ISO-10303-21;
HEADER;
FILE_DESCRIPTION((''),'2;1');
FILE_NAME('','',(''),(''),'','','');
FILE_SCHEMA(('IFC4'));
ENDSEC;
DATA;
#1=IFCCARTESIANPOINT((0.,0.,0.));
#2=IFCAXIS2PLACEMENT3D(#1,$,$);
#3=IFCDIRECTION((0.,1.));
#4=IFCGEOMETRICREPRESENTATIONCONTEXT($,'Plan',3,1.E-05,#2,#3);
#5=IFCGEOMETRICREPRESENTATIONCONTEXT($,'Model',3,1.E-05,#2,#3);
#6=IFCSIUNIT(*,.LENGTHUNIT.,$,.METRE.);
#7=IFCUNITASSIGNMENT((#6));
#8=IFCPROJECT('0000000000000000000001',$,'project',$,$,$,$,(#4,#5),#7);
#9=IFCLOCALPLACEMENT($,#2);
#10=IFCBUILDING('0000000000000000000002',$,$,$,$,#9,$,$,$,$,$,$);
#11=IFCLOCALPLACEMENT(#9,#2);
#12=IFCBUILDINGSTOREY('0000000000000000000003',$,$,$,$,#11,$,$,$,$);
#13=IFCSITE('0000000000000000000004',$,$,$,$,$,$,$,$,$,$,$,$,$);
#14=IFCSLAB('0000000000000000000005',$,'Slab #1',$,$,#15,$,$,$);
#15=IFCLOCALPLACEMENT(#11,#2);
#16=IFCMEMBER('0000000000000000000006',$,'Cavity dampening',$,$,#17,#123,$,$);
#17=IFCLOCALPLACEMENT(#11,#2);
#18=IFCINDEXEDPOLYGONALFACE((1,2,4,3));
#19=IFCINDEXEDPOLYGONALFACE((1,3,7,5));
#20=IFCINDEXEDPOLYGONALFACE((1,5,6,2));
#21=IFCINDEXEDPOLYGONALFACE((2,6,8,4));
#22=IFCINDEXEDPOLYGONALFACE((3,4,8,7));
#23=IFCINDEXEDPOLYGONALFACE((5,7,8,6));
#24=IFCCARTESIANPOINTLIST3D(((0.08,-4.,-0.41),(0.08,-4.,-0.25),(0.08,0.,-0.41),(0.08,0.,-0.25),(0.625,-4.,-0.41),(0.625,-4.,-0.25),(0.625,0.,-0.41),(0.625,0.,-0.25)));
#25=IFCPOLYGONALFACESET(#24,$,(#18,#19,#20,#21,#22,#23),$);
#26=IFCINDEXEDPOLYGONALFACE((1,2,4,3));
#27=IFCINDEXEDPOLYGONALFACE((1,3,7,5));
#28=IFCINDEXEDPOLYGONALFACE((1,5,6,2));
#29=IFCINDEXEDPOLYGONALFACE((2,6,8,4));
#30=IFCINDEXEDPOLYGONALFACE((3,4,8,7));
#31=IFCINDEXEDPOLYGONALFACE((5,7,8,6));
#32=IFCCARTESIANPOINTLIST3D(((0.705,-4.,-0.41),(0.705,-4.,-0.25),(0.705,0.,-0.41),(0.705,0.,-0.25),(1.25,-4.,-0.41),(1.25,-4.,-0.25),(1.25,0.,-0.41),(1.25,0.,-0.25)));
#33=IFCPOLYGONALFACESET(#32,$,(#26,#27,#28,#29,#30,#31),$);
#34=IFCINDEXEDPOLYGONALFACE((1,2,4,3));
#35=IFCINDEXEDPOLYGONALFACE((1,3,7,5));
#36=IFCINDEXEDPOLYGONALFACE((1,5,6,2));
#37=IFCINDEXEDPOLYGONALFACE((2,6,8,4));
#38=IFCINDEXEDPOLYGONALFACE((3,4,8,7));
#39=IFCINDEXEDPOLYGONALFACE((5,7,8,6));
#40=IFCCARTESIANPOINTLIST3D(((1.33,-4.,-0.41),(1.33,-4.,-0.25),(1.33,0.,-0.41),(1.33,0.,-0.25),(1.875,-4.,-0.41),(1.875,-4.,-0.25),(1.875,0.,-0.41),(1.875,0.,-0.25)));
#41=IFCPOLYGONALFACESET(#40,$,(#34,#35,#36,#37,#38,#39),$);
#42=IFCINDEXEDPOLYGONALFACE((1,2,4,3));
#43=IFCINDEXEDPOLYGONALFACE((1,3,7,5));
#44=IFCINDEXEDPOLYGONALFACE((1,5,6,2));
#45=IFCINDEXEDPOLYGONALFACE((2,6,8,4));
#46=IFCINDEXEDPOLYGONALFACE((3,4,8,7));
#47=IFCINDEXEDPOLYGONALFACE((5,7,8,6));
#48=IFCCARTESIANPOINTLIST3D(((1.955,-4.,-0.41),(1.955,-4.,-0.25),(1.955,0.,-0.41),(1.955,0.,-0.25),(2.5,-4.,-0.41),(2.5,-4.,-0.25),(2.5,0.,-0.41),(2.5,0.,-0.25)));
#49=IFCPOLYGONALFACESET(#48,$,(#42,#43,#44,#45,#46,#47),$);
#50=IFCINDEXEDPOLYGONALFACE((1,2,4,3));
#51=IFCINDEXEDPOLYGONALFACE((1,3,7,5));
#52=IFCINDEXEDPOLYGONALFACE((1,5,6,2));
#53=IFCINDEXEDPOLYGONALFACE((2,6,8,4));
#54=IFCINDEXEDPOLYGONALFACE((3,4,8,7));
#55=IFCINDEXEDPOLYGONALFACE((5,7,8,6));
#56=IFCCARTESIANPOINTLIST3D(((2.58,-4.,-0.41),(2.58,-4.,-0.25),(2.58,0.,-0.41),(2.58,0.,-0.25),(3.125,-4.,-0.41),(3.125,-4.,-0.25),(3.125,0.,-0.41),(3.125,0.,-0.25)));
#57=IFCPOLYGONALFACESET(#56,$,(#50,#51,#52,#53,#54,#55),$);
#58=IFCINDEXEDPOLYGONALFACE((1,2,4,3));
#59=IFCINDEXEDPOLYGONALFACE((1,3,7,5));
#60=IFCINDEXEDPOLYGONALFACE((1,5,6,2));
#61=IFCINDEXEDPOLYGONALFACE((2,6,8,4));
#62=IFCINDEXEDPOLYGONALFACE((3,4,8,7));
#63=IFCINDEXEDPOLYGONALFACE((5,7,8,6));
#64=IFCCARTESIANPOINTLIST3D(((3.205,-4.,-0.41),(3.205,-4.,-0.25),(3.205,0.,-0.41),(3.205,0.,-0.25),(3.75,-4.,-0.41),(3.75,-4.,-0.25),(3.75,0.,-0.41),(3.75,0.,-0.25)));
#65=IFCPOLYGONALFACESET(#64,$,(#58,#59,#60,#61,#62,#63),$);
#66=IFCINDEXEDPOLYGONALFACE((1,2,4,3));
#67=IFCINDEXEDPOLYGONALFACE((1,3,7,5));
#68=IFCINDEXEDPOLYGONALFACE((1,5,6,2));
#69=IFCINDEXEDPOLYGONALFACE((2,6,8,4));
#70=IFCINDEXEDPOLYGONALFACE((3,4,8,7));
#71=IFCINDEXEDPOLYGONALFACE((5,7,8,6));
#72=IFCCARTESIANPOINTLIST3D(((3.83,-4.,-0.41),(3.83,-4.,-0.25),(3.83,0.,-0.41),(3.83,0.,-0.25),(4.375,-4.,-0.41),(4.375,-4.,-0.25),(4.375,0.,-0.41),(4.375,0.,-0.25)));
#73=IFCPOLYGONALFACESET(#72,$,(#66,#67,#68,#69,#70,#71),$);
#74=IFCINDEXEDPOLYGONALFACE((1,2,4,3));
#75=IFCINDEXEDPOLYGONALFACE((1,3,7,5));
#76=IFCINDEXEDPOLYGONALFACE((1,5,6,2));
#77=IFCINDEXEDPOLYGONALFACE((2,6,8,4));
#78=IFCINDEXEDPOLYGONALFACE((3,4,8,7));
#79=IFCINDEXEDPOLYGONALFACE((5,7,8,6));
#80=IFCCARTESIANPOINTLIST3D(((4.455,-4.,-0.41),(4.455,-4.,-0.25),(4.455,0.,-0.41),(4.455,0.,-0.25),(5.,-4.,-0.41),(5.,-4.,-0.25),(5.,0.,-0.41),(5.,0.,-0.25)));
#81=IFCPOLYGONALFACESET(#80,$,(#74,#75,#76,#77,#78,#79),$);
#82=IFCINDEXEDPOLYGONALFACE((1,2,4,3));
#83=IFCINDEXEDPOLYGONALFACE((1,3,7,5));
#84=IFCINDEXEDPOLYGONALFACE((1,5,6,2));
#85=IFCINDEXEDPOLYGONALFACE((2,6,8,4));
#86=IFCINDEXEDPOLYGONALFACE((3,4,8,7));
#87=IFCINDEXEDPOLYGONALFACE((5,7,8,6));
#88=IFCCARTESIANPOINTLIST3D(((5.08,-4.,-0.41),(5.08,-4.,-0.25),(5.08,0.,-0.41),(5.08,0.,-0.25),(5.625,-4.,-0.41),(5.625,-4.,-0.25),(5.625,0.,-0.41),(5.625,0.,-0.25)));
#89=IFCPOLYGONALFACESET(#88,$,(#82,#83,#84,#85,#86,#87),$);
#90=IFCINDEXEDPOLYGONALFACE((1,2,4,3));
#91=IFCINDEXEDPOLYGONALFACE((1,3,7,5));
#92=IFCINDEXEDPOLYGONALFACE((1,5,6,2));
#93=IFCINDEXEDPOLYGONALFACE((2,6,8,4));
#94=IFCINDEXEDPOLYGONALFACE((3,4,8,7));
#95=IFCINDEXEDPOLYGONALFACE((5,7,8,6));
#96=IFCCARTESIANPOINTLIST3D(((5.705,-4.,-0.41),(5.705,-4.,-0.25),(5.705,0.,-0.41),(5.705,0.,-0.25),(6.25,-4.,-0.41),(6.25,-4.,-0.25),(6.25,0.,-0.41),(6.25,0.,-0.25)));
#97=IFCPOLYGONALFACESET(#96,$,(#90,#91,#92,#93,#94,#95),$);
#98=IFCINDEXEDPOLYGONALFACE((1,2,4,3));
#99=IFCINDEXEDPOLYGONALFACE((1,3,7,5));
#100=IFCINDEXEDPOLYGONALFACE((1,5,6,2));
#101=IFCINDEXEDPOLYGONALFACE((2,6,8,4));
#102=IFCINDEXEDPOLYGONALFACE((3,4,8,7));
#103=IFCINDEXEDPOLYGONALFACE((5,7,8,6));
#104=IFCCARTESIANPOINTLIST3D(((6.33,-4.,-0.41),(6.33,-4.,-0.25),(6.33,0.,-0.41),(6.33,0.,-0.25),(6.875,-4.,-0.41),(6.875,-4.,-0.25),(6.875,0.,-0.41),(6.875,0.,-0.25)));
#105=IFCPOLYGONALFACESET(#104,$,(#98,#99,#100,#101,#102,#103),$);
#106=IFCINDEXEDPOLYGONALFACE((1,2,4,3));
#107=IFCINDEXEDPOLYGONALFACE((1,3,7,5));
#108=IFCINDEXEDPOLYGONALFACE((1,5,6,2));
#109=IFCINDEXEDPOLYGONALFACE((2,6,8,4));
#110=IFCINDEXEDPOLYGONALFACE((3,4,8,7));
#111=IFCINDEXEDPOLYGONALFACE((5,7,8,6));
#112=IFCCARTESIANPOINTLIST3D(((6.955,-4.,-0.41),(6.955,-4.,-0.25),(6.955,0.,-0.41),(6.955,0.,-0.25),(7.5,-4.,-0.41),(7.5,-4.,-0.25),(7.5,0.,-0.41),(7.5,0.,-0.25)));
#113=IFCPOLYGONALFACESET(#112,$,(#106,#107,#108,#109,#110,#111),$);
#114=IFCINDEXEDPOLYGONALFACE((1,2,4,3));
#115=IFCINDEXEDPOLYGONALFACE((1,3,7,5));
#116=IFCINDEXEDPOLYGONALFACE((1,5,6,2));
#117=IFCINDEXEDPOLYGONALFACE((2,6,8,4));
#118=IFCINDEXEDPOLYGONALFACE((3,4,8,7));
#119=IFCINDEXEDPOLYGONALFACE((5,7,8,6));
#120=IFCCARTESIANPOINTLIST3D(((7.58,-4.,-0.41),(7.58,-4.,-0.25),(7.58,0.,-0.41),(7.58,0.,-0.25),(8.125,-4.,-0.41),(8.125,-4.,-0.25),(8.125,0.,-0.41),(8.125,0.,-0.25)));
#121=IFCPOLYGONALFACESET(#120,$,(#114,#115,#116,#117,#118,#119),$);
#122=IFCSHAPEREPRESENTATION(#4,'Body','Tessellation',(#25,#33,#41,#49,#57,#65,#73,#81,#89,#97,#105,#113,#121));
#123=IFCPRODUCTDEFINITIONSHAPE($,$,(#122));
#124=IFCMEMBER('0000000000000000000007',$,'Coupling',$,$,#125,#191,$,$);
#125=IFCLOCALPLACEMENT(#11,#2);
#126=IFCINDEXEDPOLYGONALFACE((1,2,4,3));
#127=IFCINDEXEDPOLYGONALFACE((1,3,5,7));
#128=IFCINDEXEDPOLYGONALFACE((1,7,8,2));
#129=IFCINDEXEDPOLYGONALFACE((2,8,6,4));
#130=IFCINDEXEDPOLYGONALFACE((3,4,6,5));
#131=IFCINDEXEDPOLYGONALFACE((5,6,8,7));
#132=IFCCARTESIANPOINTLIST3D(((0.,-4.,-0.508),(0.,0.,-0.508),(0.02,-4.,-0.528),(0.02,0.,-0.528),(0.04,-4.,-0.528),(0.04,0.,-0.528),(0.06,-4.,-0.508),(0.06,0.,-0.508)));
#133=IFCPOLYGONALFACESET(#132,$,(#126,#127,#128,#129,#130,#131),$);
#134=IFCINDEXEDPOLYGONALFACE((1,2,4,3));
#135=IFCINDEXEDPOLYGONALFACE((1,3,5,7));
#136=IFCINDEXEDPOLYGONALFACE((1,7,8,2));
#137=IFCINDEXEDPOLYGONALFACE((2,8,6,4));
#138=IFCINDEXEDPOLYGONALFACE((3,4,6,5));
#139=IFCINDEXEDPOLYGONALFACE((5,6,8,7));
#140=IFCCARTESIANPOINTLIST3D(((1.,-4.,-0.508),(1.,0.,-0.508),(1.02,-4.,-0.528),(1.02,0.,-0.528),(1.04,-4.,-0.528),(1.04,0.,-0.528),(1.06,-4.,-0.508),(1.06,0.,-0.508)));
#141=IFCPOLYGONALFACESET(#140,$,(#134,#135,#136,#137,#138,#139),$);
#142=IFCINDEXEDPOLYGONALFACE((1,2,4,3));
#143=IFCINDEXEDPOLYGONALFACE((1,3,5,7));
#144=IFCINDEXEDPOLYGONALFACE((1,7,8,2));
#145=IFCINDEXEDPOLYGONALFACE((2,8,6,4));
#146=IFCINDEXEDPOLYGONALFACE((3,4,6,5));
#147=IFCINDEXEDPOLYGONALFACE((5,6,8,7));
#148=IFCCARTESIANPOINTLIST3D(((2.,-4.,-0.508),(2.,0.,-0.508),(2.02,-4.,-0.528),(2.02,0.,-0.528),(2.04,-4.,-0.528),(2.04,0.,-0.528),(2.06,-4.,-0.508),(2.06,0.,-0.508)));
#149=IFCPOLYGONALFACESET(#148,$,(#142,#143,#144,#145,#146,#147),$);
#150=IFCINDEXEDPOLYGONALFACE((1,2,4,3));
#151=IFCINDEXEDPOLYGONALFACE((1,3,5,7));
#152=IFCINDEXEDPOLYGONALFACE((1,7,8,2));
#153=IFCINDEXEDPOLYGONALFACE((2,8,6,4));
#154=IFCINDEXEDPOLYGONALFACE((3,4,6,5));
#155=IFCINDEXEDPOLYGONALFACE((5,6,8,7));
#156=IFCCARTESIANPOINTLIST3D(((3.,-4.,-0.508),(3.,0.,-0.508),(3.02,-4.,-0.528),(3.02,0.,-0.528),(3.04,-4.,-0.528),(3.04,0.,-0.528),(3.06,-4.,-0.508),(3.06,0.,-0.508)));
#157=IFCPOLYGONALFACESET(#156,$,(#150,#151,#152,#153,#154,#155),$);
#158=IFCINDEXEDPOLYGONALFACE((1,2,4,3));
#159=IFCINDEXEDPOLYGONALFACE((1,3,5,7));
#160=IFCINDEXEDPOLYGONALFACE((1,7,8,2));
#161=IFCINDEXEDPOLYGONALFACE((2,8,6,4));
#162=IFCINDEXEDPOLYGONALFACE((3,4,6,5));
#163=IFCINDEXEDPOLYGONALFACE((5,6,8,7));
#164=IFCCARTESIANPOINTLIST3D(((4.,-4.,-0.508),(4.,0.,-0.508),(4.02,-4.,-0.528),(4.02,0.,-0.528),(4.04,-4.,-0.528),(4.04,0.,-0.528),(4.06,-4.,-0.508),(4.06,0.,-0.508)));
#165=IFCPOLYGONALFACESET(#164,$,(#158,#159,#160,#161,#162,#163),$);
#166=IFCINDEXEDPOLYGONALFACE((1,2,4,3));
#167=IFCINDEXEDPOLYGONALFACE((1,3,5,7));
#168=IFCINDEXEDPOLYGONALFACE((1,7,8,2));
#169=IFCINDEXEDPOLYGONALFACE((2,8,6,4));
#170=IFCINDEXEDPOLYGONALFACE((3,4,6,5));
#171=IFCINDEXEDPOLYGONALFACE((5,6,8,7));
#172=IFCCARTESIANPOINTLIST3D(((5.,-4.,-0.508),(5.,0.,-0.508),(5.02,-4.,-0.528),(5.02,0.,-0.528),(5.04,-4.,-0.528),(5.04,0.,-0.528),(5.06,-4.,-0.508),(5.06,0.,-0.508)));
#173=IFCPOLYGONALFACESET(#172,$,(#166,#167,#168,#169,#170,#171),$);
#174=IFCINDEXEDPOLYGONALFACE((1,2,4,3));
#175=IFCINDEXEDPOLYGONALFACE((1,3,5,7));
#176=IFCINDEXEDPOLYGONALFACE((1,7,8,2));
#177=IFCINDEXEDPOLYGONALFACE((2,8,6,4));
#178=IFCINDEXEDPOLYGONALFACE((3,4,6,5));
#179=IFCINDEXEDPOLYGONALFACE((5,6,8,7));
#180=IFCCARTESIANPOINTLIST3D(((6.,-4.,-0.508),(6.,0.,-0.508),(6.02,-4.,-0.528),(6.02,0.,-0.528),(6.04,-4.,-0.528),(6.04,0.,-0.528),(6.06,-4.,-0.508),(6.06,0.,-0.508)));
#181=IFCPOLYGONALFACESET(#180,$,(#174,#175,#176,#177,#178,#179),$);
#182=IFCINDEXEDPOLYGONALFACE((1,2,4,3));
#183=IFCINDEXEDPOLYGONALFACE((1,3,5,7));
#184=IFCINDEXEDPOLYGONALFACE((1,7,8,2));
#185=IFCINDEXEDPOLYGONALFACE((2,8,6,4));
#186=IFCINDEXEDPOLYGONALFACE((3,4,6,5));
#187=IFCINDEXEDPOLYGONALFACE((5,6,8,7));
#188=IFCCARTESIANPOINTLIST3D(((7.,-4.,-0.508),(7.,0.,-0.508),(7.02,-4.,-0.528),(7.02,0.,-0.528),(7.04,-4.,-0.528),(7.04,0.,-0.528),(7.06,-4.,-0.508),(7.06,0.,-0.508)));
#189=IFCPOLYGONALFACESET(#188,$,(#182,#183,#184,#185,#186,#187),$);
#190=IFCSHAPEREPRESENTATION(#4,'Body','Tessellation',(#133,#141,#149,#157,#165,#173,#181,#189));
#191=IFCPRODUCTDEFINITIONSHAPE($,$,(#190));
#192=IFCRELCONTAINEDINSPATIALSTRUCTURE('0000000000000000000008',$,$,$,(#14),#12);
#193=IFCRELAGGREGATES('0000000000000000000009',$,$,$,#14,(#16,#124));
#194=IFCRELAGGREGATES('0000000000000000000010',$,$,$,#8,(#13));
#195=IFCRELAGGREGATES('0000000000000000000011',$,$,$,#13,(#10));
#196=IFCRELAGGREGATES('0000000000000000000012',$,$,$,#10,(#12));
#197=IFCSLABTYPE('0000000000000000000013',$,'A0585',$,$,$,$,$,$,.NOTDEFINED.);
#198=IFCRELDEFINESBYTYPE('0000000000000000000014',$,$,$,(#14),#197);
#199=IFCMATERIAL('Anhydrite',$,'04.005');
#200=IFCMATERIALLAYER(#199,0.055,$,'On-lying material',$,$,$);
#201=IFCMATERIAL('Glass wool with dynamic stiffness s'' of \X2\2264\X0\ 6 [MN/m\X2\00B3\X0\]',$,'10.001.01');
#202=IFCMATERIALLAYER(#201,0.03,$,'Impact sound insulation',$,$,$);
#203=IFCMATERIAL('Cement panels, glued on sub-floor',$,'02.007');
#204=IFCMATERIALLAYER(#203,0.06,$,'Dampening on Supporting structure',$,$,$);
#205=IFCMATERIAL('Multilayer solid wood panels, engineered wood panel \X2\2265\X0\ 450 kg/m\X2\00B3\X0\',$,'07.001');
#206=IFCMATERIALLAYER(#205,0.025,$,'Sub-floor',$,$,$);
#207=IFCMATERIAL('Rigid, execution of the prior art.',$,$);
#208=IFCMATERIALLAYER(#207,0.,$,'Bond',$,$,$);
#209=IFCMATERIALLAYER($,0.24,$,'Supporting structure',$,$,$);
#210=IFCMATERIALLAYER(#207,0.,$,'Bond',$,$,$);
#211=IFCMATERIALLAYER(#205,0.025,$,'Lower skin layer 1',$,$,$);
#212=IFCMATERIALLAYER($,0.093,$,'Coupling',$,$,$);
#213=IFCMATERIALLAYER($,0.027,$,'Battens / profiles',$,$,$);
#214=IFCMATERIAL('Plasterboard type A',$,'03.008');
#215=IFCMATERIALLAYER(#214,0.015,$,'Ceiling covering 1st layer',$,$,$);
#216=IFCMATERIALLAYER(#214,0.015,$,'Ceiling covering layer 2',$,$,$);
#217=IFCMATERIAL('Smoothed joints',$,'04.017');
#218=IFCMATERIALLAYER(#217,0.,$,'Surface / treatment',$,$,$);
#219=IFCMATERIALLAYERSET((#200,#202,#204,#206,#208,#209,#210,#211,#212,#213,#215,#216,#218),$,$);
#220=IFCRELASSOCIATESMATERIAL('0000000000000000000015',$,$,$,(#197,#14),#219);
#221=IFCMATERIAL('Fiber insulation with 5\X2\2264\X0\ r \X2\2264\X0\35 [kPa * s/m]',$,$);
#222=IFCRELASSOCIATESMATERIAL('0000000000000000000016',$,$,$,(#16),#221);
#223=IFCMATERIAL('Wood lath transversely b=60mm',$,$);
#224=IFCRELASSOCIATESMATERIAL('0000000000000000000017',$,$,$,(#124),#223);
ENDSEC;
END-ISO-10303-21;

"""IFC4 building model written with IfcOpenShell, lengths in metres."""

from ifc_helpers import new_model, si_unit, direction, frame, frame_2d, origin, place, context, project, spatial, polyline, rectangle, outline, extrude, material, layer, layer_set, type_object, element, aggregate, save


model = new_model("IFC4")

# Units and contexts
plan_context = context("Plan", 3, precision=1e-05, world=origin(), true_north=direction((0.0, 1.0)))
model_context = context("Model", 3, precision=1e-05, world=origin(), true_north=direction((0.0, 1.0)))
ifc_project = project(units=[si_unit("LENGTHUNIT", "METRE")], contexts=[plan_context, model_context])

# Site, building, storey
site = spatial("IfcSite", under=ifc_project)
building_placement = place(None, origin())
building = spatial("IfcBuilding", under=site, at=building_placement)
storey_placement = place(building_placement, origin())
storey = spatial("IfcBuildingStorey", under=building, at=storey_placement)

# Slab, members
ifc_material_1 = material(Name="Anhydrite", Category="04.005")
ifc_layer_1 = layer(ifc_material_1, 0.055, Name="On-lying material")
ifc_material_2 = material(Name="Glass wool with dynamic stiffness s' of ≤ 6 [MN/m³]", Category="10.001.01")
ifc_layer_2 = layer(ifc_material_2, 0.03, Name="Impact sound insulation")
ifc_material_3 = material(Name="Cement panels, glued on sub-floor", Category="02.007")
ifc_layer_3 = layer(ifc_material_3, 0.06, Name="Dampening on Supporting structure")
ifc_material_4 = material(Name="Multilayer solid wood panels, engineered wood panel ≥ 450 kg/m³", Category="07.001")
ifc_layer_4 = layer(ifc_material_4, 0.025, Name="Sub-floor")
ifc_material_5 = material(Name="Rigid, execution of the prior art.")
ifc_layer_5 = layer(ifc_material_5, 0.0, Name="Bond")
ifc_layer_6 = layer(None, 0.24, Name="Supporting structure")
ifc_layer_7 = layer(ifc_material_5, 0.0, Name="Bond")
ifc_layer_8 = layer(ifc_material_4, 0.025, Name="Lower skin layer 1")
ifc_layer_9 = layer(None, 0.093, Name="Coupling")
ifc_layer_10 = layer(None, 0.027, Name="Battens / profiles")
ifc_material_6 = material(Name="Plasterboard type A", Category="03.008")
ifc_layer_11 = layer(ifc_material_6, 0.015, Name="Ceiling covering 1st layer")
ifc_layer_12 = layer(ifc_material_6, 0.015, Name="Ceiling covering layer 2")
ifc_material_7 = material(Name="Smoothed joints", Category="04.017")
ifc_layer_13 = layer(ifc_material_7, 0.0, Name="Surface / treatment")
ifc_layer_set = layer_set([ifc_layer_1, ifc_layer_2, ifc_layer_3, ifc_layer_4, ifc_layer_5, ifc_layer_6, ifc_layer_7, ifc_layer_8, ifc_layer_9, ifc_layer_10, ifc_layer_11, ifc_layer_12, ifc_layer_13])
slab_type = type_object("IfcSlabType", Name="A0585", PredefinedType="NOTDEFINED", material=ifc_layer_set)
slab_placement = place(None, frame((0.0, 0.0, 0.0), z_axis=(0.0, 0.0, -1.0), x_axis=(1.0, 0.0, 0.0)))
slab = element("IfcSlab", 1, at=slab_placement, inside=storey, type_object=slab_type, material=ifc_layer_set, Name="Slab #1")
ifc_material_8 = material(Name="Fiber insulation with 5≤ r ≤35 [kPa * s/m]")
member_1_placement = place(slab_placement, origin())
member_1 = element("IfcMember", 2, at=member_1_placement, material=ifc_material_8, Name="Cavity dampening", context=plan_context, shape_type="SweptSolid", body=[
    extrude(rectangle(XDim=0.545, YDim=0.16, at=frame_2d((0.2725, 0.08), x_axis=(1.0, 0.0))), frame((0.08, 4.0, 0.25), z_axis=(0.0, -1.0, 0.0), x_axis=(1.0, 0.0, 0.0)), (0.0, 0.0, 1.0), 4.0),
    extrude(rectangle(XDim=0.545, YDim=0.16, at=frame_2d((0.2725, 0.08), x_axis=(1.0, 0.0))), frame((0.705, 4.0, 0.25), z_axis=(0.0, -1.0, 0.0), x_axis=(1.0, 0.0, 0.0)), (0.0, 0.0, 1.0), 4.0),
    extrude(rectangle(XDim=0.545, YDim=0.16, at=frame_2d((0.2725, 0.08), x_axis=(1.0, 0.0))), frame((1.33, 4.0, 0.25), z_axis=(0.0, -1.0, 0.0), x_axis=(1.0, 0.0, 0.0)), (0.0, 0.0, 1.0), 4.0),
    extrude(rectangle(XDim=0.545, YDim=0.16, at=frame_2d((0.2725, 0.08), x_axis=(1.0, 0.0))), frame((1.955, 4.0, 0.25), z_axis=(0.0, -1.0, 0.0), x_axis=(1.0, 0.0, 0.0)), (0.0, 0.0, 1.0), 4.0),
    extrude(rectangle(XDim=0.545, YDim=0.16, at=frame_2d((0.2725, 0.08), x_axis=(1.0, 0.0))), frame((2.58, 4.0, 0.25), z_axis=(0.0, -1.0, 0.0), x_axis=(1.0, 0.0, 0.0)), (0.0, 0.0, 1.0), 4.0),
    extrude(rectangle(XDim=0.545, YDim=0.16, at=frame_2d((0.2725, 0.08), x_axis=(1.0, 0.0))), frame((3.205, 4.0, 0.25), z_axis=(0.0, -1.0, 0.0), x_axis=(1.0, 0.0, 0.0)), (0.0, 0.0, 1.0), 4.0),
    extrude(rectangle(XDim=0.545, YDim=0.16, at=frame_2d((0.2725, 0.08), x_axis=(1.0, 0.0))), frame((3.83, 4.0, 0.25), z_axis=(0.0, -1.0, 0.0), x_axis=(1.0, 0.0, 0.0)), (0.0, 0.0, 1.0), 4.0),
    extrude(rectangle(XDim=0.545, YDim=0.16, at=frame_2d((0.2725, 0.08), x_axis=(1.0, 0.0))), frame((4.455, 4.0, 0.25), z_axis=(0.0, -1.0, 0.0), x_axis=(1.0, 0.0, 0.0)), (0.0, 0.0, 1.0), 4.0),
    extrude(rectangle(XDim=0.545, YDim=0.16, at=frame_2d((0.2725, 0.08), x_axis=(1.0, 0.0))), frame((5.08, 4.0, 0.25), z_axis=(0.0, -1.0, 0.0), x_axis=(1.0, 0.0, 0.0)), (0.0, 0.0, 1.0), 4.0),
    extrude(rectangle(XDim=0.545, YDim=0.16, at=frame_2d((0.2725, 0.08), x_axis=(1.0, 0.0))), frame((5.705, 4.0, 0.25), z_axis=(0.0, -1.0, 0.0), x_axis=(1.0, 0.0, 0.0)), (0.0, 0.0, 1.0), 4.0),
    extrude(rectangle(XDim=0.545, YDim=0.16, at=frame_2d((0.2725, 0.08), x_axis=(1.0, 0.0))), frame((6.33, 4.0, 0.25), z_axis=(0.0, -1.0, 0.0), x_axis=(1.0, 0.0, 0.0)), (0.0, 0.0, 1.0), 4.0),
    extrude(rectangle(XDim=0.545, YDim=0.16, at=frame_2d((0.2725, 0.08), x_axis=(1.0, 0.0))), frame((6.955, 4.0, 0.25), z_axis=(0.0, -1.0, 0.0), x_axis=(1.0, 0.0, 0.0)), (0.0, 0.0, 1.0), 4.0),
    extrude(rectangle(XDim=0.545, YDim=0.16, at=frame_2d((0.2725, 0.08), x_axis=(1.0, 0.0))), frame((7.58, 4.0, 0.25), z_axis=(0.0, -1.0, 0.0), x_axis=(1.0, 0.0, 0.0)), (0.0, 0.0, 1.0), 4.0),
])
ifc_material_9 = material(Name="Wood lath transversely b=60mm")
member_2_placement = place(slab_placement, origin())
member_2 = element("IfcMember", 3, at=member_2_placement, material=ifc_material_9, Name="Coupling", context=plan_context, shape_type="SweptSolid", body=[
    extrude(outline(polyline([(0.0, 0.0), (0.06, 0.0), (0.04, 0.02), (0.02, 0.02), (0.0, 0.0)])), frame((0.0, 4.0, 0.508), z_axis=(0.0, -1.0, 0.0), x_axis=(1.0, 0.0, 0.0)), (0.0, 0.0, 1.0), 4.0),
    extrude(outline(polyline([(0.0, 0.0), (0.06, 0.0), (0.04, 0.02), (0.02, 0.02), (0.0, 0.0)])), frame((1.0, 4.0, 0.508), z_axis=(0.0, -1.0, 0.0), x_axis=(1.0, 0.0, 0.0)), (0.0, 0.0, 1.0), 4.0),
    extrude(outline(polyline([(0.0, 0.0), (0.06, 0.0), (0.04, 0.02), (0.02, 0.02), (0.0, 0.0)])), frame((2.0, 4.0, 0.508), z_axis=(0.0, -1.0, 0.0), x_axis=(1.0, 0.0, 0.0)), (0.0, 0.0, 1.0), 4.0),
    extrude(outline(polyline([(0.0, 0.0), (0.06, 0.0), (0.04, 0.02), (0.02, 0.02), (0.0, 0.0)])), frame((3.0, 4.0, 0.508), z_axis=(0.0, -1.0, 0.0), x_axis=(1.0, 0.0, 0.0)), (0.0, 0.0, 1.0), 4.0),
    extrude(outline(polyline([(0.0, 0.0), (0.06, 0.0), (0.04, 0.02), (0.02, 0.02), (0.0, 0.0)])), frame((4.0, 4.0, 0.508), z_axis=(0.0, -1.0, 0.0), x_axis=(1.0, 0.0, 0.0)), (0.0, 0.0, 1.0), 4.0),
    extrude(outline(polyline([(0.0, 0.0), (0.06, 0.0), (0.04, 0.02), (0.02, 0.02), (0.0, 0.0)])), frame((5.0, 4.0, 0.508), z_axis=(0.0, -1.0, 0.0), x_axis=(1.0, 0.0, 0.0)), (0.0, 0.0, 1.0), 4.0),
    extrude(outline(polyline([(0.0, 0.0), (0.06, 0.0), (0.04, 0.02), (0.02, 0.02), (0.0, 0.0)])), frame((6.0, 4.0, 0.508), z_axis=(0.0, -1.0, 0.0), x_axis=(1.0, 0.0, 0.0)), (0.0, 0.0, 1.0), 4.0),
    extrude(outline(polyline([(0.0, 0.0), (0.06, 0.0), (0.04, 0.02), (0.02, 0.02), (0.0, 0.0)])), frame((7.0, 4.0, 0.508), z_axis=(0.0, -1.0, 0.0), x_axis=(1.0, 0.0, 0.0)), (0.0, 0.0, 1.0), 4.0),
])
aggregate(slab, [member_1, member_2])

save(model, "model.ifc")
